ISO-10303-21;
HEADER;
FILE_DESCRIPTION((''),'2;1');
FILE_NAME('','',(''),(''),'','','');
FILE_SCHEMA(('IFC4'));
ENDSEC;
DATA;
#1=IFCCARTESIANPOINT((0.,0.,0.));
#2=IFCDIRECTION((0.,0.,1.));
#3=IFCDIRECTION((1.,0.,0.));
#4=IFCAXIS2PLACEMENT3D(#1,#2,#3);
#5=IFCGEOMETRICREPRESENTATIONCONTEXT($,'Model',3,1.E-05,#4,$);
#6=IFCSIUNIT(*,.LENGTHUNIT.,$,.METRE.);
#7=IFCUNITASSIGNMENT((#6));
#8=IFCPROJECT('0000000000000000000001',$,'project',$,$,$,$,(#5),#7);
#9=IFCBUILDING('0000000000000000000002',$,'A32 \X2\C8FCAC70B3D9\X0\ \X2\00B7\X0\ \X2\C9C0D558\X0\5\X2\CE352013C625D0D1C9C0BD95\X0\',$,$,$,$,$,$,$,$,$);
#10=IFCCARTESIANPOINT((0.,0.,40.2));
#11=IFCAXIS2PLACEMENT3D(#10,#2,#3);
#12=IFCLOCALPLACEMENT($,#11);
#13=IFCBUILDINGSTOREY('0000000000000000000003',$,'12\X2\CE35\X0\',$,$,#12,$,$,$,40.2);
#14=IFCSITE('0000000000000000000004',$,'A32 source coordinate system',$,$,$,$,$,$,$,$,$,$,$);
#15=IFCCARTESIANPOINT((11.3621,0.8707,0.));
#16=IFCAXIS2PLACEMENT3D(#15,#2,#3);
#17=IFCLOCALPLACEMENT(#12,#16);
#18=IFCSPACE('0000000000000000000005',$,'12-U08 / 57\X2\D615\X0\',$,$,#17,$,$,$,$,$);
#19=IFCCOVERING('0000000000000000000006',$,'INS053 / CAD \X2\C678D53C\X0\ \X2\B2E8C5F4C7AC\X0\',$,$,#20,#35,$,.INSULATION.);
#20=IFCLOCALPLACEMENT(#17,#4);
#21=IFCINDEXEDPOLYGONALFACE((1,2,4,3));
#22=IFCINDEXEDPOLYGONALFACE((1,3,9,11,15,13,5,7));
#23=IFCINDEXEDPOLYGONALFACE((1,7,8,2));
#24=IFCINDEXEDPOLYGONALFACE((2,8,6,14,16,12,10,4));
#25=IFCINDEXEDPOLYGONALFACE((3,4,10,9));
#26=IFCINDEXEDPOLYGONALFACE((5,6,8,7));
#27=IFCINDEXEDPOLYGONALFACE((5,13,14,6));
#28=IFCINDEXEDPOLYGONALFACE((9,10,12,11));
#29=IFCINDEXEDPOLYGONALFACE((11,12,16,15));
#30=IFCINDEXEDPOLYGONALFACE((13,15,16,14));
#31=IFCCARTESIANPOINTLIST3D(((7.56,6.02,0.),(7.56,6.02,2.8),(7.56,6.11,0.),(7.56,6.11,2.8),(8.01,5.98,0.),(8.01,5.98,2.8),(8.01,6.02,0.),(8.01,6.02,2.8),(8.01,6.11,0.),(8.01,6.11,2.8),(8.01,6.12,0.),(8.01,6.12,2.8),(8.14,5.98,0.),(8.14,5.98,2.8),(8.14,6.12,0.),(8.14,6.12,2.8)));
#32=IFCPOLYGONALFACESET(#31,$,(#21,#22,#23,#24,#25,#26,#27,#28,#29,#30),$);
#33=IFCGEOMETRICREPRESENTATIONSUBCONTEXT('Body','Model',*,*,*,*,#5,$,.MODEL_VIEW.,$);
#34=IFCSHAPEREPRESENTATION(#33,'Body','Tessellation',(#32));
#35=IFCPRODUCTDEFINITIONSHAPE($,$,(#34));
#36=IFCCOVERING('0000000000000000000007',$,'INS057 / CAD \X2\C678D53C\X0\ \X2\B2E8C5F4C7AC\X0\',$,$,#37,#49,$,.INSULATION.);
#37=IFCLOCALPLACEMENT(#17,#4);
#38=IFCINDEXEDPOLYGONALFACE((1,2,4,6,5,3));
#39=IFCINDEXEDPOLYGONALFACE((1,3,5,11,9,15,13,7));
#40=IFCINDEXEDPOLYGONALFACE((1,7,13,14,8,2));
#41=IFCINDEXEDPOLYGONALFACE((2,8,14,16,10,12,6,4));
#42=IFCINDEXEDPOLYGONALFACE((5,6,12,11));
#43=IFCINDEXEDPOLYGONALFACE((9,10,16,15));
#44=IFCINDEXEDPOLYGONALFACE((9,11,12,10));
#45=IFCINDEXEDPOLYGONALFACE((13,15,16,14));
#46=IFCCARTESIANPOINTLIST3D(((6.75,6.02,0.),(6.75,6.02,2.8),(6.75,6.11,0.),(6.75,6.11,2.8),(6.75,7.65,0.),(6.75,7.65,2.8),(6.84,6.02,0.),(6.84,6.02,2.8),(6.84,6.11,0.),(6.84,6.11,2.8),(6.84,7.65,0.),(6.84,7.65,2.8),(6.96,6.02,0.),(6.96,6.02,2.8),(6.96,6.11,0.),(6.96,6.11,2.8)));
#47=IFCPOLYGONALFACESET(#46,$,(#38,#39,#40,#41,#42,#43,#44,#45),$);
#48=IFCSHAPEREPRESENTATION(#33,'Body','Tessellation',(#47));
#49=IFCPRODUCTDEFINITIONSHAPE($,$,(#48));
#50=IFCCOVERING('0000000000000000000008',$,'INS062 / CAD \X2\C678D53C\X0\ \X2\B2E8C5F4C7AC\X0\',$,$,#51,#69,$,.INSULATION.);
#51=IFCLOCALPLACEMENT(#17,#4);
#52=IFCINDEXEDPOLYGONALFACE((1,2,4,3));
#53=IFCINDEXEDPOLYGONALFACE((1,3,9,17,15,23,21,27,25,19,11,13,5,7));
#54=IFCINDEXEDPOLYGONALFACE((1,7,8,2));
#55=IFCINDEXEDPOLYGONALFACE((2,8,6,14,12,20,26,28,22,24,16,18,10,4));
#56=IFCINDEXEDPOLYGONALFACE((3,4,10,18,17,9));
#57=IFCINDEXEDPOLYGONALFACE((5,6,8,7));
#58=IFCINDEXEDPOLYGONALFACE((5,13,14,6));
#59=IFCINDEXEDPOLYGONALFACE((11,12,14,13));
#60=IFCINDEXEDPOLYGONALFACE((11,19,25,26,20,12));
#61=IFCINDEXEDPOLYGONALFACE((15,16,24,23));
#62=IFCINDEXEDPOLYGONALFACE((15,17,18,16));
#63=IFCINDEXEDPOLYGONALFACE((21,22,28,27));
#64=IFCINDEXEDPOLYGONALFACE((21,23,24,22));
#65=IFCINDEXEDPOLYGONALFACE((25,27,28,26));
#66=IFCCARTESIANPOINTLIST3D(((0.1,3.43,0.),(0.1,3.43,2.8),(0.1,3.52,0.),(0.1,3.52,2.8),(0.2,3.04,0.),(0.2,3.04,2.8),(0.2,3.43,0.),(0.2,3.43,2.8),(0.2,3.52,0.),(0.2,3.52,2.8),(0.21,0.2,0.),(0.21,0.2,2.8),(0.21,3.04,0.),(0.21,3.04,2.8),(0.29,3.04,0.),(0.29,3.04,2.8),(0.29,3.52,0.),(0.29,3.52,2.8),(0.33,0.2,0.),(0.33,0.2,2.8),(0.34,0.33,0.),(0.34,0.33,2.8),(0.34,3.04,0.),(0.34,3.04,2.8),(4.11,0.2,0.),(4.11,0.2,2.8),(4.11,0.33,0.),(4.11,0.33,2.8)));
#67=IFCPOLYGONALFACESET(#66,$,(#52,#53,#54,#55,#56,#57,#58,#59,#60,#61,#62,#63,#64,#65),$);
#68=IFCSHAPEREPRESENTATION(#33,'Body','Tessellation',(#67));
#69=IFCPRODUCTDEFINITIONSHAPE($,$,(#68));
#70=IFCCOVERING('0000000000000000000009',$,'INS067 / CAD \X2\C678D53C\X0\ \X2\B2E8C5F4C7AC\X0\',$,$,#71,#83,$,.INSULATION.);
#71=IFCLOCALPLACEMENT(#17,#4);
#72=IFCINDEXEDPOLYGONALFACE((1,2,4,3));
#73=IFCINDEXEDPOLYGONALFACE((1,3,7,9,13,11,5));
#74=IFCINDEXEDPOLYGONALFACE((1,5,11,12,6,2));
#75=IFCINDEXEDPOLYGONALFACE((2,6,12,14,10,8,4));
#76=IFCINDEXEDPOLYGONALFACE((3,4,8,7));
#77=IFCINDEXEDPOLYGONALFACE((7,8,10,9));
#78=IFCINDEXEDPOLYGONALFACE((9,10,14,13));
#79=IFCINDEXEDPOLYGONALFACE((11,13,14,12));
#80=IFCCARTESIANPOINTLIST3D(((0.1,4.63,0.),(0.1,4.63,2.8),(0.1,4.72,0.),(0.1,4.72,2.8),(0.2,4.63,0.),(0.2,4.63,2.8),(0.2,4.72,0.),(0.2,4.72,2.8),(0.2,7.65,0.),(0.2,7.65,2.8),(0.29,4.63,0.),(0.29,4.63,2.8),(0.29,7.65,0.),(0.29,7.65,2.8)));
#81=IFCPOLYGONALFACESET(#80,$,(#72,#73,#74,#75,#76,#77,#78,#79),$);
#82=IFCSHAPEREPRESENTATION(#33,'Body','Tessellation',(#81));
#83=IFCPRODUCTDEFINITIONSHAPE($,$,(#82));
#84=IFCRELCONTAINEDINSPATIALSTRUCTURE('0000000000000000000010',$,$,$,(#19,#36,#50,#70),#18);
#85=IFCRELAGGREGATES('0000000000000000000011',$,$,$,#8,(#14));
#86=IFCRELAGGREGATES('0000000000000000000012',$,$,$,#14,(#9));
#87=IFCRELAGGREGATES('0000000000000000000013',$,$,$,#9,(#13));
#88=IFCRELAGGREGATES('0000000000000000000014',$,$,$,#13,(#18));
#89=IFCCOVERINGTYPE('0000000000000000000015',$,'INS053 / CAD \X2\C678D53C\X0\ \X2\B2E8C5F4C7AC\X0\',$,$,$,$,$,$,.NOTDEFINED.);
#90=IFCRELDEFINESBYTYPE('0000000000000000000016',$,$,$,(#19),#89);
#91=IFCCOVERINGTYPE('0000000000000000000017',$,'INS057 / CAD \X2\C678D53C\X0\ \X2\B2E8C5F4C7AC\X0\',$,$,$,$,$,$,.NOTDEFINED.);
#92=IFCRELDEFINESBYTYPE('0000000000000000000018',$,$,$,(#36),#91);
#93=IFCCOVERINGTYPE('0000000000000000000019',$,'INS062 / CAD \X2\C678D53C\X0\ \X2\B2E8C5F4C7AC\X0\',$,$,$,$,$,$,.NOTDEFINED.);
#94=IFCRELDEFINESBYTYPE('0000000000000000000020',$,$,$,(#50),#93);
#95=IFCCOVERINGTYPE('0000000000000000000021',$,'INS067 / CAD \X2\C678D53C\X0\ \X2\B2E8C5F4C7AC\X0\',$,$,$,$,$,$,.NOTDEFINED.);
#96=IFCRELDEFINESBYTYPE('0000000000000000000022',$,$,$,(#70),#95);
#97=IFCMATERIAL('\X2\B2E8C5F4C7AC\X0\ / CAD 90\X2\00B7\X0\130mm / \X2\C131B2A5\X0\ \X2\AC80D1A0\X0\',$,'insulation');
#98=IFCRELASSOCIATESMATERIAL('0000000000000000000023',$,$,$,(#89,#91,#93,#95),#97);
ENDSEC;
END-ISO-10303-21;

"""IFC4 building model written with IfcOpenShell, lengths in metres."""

from ifc_helpers import new_model, si_unit, frame, origin, origin_with_axes, place, context, subcontext, project, spatial, polyline, outline, extrude, source, transform, mapped, material, type_object, type_shapes, element, save


model = new_model("IFC4")

# Units and contexts
model_context = context("Model", 3, precision=1e-05, world=origin_with_axes())
body_context = subcontext(model_context, "Body", "Model", "MODEL_VIEW")
ifc_project = project(units=[si_unit("LENGTHUNIT", "METRE")], contexts=[model_context])

# Site, building, storey, space
site = spatial("IfcSite", under=ifc_project, Name="A32 source coordinate system")
building = spatial("IfcBuilding", under=site, Name="A32 주거동 · 지하5층–옥탑지붕")
storey_placement = place(None, frame((0.0, 0.0, 40.2), z_axis=(0.0, 0.0, 1.0), x_axis=(1.0, 0.0, 0.0)))
storey = spatial("IfcBuildingStorey", under=building, at=storey_placement, Name="12층", Elevation=40.2)
space_1_placement = place(storey_placement, frame((11.3621, 0.8707, 0.0), z_axis=(0.0, 0.0, 1.0), x_axis=(1.0, 0.0, 0.0)))
space_1 = spatial("IfcSpace", under=storey, at=space_1_placement, Name="12-U08 / 57형")

# Coverings
ifc_material = material(Name="단열재 / CAD 90·130mm / 성능 검토", Category="insulation")
covering_type_1 = type_object("IfcCoveringType", Name="INS053 / CAD 외피 단열재", PredefinedType="NOTDEFINED", material=ifc_material)
shared_shape_1 = source(origin(), body_context, "Body", "SweptSolid", [
    extrude(outline(polyline([(8.01, 6.12), (8.14, 6.12), (8.14, 5.98), (8.01, 5.98), (8.01, 6.02), (7.56, 6.02), (7.56, 6.11), (8.01, 6.11), (8.01, 6.12)])), origin(), (0.0, 0.0, 1.0), 2.8),
])
type_shapes(covering_type_1, [shared_shape_1])
covering_1_placement = place(space_1_placement, origin_with_axes())
element("IfcCovering", 1, at=covering_1_placement, inside=space_1, type_object=covering_type_1, Name="INS053 / CAD 외피 단열재", PredefinedType="INSULATION", context=body_context, shape_type="MappedRepresentation", body=[
    mapped(shared_shape_1, transform((0.0, 0.0, 0.0), scale=1.0)),
])
covering_type_2 = type_object("IfcCoveringType", Name="INS057 / CAD 외피 단열재", PredefinedType="NOTDEFINED", material=ifc_material)
shared_shape_2 = source(origin(), body_context, "Body", "SweptSolid", [
    extrude(outline(polyline([(6.84, 6.11), (6.96, 6.11), (6.96, 6.02), (6.84, 6.02), (6.75, 6.02), (6.75, 6.11), (6.75, 7.65), (6.84, 7.65), (6.84, 6.11)])), origin(), (0.0, 0.0, 1.0), 2.8),
])
type_shapes(covering_type_2, [shared_shape_2])
covering_2_placement = place(space_1_placement, origin_with_axes())
element("IfcCovering", 2, at=covering_2_placement, inside=space_1, type_object=covering_type_2, Name="INS057 / CAD 외피 단열재", PredefinedType="INSULATION", context=body_context, shape_type="MappedRepresentation", body=[
    mapped(shared_shape_2, transform((0.0, 0.0, 0.0), scale=1.0)),
])
covering_type_3 = type_object("IfcCoveringType", Name="INS062 / CAD 외피 단열재", PredefinedType="NOTDEFINED", material=ifc_material)
shared_shape_3 = source(origin(), body_context, "Body", "SweptSolid", [
    extrude(outline(polyline([(4.11, 0.2), (0.33, 0.2), (0.21, 0.2), (0.21, 3.04), (0.2, 3.04), (0.2, 3.43), (0.1, 3.43), (0.1, 3.52), (0.2, 3.52), (0.29, 3.52), (0.29, 3.04), (0.34, 3.04), (0.34, 0.33), (4.11, 0.33), (4.11, 0.2)])), origin(), (0.0, 0.0, 1.0), 2.8),
])
type_shapes(covering_type_3, [shared_shape_3])
covering_3_placement = place(space_1_placement, origin_with_axes())
element("IfcCovering", 3, at=covering_3_placement, inside=space_1, type_object=covering_type_3, Name="INS062 / CAD 외피 단열재", PredefinedType="INSULATION", context=body_context, shape_type="MappedRepresentation", body=[
    mapped(shared_shape_3, transform((0.0, 0.0, 0.0), scale=1.0)),
])
covering_type_4 = type_object("IfcCoveringType", Name="INS067 / CAD 외피 단열재", PredefinedType="NOTDEFINED", material=ifc_material)
shared_shape_4 = source(origin(), body_context, "Body", "SweptSolid", [
    extrude(outline(polyline([(0.1, 4.72), (0.2, 4.72), (0.2, 7.65), (0.29, 7.65), (0.29, 4.63), (0.2, 4.63), (0.1, 4.63), (0.1, 4.72)])), origin(), (0.0, 0.0, 1.0), 2.8),
])
type_shapes(covering_type_4, [shared_shape_4])
covering_4_placement = place(space_1_placement, origin_with_axes())
element("IfcCovering", 4, at=covering_4_placement, inside=space_1, type_object=covering_type_4, Name="INS067 / CAD 외피 단열재", PredefinedType="INSULATION", context=body_context, shape_type="MappedRepresentation", body=[
    mapped(shared_shape_4, transform((0.0, 0.0, 0.0), scale=1.0)),
])

save(model, "model.ifc")
